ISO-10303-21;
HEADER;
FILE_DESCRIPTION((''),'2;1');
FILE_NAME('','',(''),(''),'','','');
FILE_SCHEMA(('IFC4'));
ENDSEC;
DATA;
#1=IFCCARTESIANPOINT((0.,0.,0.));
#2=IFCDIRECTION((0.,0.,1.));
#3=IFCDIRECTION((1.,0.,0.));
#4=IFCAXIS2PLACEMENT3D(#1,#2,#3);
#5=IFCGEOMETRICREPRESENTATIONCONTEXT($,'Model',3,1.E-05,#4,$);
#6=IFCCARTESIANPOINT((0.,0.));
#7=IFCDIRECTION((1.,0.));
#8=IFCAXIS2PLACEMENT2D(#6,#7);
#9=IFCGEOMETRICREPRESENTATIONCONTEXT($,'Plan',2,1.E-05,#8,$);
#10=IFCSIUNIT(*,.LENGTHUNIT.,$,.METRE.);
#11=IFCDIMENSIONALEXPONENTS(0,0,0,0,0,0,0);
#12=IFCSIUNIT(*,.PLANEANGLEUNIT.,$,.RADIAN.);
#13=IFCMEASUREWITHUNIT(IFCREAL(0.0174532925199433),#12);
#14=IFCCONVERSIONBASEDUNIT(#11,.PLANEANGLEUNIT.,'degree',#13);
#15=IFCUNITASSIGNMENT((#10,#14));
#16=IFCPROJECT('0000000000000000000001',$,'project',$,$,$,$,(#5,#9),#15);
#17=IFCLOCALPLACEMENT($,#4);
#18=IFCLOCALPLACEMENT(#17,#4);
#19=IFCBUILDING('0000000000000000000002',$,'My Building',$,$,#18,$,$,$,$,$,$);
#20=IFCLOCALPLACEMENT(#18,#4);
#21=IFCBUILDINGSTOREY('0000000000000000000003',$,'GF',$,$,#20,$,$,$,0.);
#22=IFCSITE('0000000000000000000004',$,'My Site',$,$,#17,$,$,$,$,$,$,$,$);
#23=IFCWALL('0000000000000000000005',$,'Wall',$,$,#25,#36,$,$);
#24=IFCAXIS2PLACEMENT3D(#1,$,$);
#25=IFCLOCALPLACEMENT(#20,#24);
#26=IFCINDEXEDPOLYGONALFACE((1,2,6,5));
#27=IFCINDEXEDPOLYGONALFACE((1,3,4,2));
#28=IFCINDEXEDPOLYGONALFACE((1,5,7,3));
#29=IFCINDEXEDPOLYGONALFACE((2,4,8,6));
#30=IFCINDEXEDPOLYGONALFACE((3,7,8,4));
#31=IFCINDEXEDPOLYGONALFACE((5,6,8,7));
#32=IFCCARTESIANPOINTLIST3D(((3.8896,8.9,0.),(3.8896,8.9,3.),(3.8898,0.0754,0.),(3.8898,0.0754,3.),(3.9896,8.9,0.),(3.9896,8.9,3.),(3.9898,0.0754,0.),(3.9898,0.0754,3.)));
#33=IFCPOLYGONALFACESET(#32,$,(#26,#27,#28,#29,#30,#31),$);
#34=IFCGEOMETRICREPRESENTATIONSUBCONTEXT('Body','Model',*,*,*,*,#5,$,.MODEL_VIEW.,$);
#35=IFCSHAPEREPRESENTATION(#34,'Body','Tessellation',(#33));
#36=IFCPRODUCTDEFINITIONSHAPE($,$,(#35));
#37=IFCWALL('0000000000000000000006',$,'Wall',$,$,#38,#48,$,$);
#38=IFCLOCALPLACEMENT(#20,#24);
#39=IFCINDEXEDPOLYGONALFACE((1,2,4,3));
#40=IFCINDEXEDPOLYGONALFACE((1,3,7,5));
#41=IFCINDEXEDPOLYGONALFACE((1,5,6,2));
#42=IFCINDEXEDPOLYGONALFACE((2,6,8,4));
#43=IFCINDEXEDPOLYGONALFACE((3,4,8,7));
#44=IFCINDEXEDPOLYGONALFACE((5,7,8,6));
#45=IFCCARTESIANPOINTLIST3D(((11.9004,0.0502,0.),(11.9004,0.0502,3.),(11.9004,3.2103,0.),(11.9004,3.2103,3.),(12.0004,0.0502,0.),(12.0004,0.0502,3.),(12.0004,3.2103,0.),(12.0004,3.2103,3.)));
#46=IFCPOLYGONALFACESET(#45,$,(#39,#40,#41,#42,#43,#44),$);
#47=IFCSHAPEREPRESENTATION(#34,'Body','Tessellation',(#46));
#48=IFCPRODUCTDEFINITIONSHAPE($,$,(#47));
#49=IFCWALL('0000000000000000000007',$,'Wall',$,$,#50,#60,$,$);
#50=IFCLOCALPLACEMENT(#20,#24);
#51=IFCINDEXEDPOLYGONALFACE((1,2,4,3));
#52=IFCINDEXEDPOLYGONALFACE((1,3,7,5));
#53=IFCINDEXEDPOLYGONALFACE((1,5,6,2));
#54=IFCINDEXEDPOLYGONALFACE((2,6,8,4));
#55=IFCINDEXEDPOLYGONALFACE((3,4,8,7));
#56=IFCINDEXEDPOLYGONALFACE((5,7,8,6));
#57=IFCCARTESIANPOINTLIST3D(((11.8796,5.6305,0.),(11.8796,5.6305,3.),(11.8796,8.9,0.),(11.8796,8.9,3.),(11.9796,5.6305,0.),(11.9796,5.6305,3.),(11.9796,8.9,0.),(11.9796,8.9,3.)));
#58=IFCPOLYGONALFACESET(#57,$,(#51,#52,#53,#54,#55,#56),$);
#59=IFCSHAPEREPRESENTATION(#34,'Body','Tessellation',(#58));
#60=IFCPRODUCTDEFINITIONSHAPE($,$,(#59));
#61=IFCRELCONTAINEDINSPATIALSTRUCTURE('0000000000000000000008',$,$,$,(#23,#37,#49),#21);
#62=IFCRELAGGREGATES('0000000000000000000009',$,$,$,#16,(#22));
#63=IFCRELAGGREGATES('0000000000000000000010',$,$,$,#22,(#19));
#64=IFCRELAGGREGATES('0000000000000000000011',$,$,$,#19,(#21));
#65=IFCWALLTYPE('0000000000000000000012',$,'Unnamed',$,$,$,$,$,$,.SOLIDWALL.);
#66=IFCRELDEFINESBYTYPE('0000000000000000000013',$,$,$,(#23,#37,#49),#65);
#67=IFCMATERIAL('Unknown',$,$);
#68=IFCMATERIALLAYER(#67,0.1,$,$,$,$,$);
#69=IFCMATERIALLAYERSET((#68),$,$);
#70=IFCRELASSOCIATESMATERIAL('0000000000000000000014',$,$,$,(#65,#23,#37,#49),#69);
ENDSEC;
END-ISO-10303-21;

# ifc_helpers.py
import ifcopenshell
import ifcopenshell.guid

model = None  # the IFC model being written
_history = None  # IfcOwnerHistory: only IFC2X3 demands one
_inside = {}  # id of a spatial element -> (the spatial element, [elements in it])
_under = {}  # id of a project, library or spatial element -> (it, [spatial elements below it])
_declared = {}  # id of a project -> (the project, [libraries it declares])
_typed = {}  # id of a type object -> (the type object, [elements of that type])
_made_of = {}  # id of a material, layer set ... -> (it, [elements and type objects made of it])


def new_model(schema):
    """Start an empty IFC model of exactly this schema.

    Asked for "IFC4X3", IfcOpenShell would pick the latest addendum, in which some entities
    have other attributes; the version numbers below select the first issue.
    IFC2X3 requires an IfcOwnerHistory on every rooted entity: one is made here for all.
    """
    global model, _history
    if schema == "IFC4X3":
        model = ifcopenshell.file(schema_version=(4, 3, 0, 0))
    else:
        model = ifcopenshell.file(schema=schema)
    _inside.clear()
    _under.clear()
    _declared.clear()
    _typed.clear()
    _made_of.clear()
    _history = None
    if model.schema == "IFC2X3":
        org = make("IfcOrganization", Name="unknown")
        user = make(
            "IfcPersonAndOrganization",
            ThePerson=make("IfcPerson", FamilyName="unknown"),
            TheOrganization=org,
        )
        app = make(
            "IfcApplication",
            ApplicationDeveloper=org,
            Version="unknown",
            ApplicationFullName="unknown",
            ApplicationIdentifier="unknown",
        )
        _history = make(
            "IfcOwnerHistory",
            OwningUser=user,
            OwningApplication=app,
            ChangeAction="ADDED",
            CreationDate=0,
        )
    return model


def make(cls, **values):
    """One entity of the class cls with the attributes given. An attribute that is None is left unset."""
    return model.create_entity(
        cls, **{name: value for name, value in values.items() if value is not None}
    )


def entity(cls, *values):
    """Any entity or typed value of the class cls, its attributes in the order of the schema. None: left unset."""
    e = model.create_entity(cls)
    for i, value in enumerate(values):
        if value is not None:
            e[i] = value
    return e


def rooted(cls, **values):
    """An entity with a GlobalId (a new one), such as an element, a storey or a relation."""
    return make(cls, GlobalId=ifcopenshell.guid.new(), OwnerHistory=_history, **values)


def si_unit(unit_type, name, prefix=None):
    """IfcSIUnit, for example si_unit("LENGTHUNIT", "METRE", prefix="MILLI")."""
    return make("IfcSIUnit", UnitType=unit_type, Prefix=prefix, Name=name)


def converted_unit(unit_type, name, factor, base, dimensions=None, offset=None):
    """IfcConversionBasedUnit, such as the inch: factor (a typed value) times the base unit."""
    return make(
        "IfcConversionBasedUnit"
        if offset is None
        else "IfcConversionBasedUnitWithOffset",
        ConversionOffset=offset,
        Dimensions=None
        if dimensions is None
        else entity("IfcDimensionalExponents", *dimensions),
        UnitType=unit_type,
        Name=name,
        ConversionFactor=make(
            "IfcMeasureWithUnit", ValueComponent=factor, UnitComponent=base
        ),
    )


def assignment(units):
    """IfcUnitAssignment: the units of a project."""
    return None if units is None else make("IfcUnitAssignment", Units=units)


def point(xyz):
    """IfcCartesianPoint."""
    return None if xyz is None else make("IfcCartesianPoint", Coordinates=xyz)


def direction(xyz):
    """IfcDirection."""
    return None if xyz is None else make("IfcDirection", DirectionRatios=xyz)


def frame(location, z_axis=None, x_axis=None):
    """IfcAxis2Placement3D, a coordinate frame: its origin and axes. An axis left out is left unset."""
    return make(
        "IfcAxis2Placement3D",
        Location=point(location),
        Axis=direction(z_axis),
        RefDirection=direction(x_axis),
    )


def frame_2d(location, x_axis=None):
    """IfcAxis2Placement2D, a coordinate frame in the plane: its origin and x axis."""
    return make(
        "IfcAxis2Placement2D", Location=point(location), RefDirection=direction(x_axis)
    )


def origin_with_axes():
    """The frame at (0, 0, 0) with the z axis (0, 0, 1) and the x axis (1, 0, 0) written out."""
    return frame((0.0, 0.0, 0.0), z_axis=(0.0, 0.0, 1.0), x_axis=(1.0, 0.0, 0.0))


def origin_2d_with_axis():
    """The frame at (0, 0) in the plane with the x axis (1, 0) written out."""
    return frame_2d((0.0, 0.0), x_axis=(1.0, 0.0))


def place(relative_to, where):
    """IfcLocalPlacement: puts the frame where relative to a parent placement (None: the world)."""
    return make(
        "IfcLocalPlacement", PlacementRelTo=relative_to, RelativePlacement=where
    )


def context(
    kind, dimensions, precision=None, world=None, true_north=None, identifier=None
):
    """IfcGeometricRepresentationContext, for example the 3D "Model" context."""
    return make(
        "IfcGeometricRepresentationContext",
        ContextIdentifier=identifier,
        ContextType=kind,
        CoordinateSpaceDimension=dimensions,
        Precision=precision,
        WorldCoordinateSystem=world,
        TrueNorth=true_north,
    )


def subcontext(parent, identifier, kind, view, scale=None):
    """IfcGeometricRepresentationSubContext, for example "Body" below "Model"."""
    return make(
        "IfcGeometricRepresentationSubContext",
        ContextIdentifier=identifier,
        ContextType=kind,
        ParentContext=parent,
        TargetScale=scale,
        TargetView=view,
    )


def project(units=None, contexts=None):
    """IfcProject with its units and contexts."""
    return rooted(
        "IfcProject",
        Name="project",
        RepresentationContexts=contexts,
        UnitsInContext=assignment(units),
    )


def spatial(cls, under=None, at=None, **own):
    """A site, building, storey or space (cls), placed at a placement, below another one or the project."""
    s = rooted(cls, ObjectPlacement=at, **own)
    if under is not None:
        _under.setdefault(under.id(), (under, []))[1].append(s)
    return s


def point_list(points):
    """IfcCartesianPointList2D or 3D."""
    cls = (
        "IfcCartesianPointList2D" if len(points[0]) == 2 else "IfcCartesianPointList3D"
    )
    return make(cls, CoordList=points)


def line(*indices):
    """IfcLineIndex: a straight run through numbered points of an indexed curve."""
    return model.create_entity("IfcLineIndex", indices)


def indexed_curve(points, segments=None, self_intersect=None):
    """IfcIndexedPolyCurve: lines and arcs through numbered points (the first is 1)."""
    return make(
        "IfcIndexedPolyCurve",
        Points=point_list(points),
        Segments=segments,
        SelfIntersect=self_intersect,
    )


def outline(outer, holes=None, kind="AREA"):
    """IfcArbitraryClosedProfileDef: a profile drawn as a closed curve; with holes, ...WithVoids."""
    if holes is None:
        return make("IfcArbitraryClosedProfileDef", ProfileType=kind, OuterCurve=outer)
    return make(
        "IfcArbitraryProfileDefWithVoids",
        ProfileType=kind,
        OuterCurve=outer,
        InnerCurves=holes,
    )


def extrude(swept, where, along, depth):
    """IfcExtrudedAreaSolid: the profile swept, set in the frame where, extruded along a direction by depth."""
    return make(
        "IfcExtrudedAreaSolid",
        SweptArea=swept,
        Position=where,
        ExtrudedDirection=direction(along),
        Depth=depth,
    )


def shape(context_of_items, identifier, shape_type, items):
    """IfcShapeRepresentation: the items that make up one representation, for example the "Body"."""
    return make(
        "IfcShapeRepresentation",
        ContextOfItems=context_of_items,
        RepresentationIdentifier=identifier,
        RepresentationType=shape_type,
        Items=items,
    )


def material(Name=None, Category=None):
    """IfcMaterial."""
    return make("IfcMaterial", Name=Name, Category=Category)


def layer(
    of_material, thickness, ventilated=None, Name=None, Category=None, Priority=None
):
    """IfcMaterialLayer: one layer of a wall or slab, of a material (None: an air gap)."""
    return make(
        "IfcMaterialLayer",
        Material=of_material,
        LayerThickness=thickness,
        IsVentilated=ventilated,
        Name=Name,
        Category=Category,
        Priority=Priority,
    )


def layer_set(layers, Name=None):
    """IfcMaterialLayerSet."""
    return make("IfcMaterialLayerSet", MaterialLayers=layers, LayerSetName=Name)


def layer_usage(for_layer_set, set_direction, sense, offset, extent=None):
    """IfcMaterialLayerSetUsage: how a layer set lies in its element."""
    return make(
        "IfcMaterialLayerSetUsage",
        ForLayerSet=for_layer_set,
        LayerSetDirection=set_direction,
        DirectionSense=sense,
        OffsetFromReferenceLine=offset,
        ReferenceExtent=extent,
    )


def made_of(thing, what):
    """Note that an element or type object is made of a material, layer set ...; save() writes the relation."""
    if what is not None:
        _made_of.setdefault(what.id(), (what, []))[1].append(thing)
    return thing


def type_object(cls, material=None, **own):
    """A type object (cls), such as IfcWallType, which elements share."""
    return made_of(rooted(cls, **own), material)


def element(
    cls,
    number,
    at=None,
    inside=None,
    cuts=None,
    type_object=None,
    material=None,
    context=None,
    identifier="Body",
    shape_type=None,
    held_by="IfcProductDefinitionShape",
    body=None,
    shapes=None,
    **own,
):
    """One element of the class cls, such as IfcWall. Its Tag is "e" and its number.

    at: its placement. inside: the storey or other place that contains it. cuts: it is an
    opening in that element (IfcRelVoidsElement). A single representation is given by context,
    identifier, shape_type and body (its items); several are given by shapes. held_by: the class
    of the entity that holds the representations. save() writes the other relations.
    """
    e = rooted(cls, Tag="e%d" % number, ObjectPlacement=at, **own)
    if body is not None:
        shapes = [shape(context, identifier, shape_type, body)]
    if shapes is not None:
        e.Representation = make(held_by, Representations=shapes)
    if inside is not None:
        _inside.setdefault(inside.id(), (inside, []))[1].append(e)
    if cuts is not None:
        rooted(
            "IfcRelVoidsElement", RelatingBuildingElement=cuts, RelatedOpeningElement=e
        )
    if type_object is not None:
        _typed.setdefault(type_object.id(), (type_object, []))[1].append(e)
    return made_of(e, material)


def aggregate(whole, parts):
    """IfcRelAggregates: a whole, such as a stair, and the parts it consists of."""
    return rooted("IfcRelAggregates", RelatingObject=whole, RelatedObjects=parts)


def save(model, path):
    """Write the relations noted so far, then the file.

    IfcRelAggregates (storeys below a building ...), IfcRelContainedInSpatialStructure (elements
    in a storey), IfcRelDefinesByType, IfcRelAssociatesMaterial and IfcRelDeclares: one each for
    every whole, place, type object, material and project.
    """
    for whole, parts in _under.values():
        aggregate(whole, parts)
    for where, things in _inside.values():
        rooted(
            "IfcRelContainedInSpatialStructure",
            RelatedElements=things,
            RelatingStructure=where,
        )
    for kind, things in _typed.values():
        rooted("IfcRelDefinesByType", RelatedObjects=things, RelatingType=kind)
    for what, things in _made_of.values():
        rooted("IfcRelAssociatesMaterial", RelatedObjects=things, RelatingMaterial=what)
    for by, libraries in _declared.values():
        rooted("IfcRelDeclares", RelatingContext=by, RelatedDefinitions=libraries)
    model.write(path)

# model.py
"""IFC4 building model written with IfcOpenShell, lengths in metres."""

from ifc_helpers import new_model, entity, si_unit, converted_unit, frame, origin_with_axes, origin_2d_with_axis, place, context, subcontext, project, spatial, line, indexed_curve, outline, extrude, material, layer, layer_set, layer_usage, type_object, element, save


model = new_model("IFC4")

# Units and contexts
model_context = context("Model", 3, precision=1e-05, world=origin_with_axes())
plan_context = context("Plan", 2, precision=1e-05, world=origin_2d_with_axis())
body_context_1 = subcontext(model_context, "Body", "Model", "MODEL_VIEW")
ifc_project = project(units=[si_unit("LENGTHUNIT", "METRE"), converted_unit("PLANEANGLEUNIT", "degree", entity("IfcReal", 0.0174532925199433), si_unit("PLANEANGLEUNIT", "RADIAN"), dimensions=[0, 0, 0, 0, 0, 0, 0])], contexts=[model_context, plan_context])

# Site, building, storey
site_placement = place(None, origin_with_axes())
site = spatial("IfcSite", under=ifc_project, at=site_placement, Name="My Site")
building_placement = place(site_placement, origin_with_axes())
building = spatial("IfcBuilding", under=site, at=building_placement, Name="My Building")
storey_placement = place(building_placement, origin_with_axes())
storey = spatial("IfcBuildingStorey", under=building, at=storey_placement, Name="GF", Elevation=0.0)

# Shared definitions
ifc_material = material(Name="Unknown")
ifc_layer = layer(ifc_material, 0.1)
ifc_layer_set = layer_set([ifc_layer])
wall_type = type_object("IfcWallType", Name="Unnamed", PredefinedType="SOLIDWALL", material=ifc_layer_set)

# Walls
ifc_layer_usage_1 = layer_usage(ifc_layer_set, "AXIS2", "POSITIVE", 0.0)
wall_1_placement = place(storey_placement, frame((3.9898, 0.0754, 0.0), z_axis=(0.0, 0.0, 1.0), x_axis=(-0.000021, 1.0, 0.0)))
element("IfcWall", 1, at=wall_1_placement, inside=storey, type_object=wall_type, material=ifc_layer_usage_1, Name="Wall", context=body_context_1, shape_type="SweptSolid", body=[
    extrude(outline(indexed_curve([(0.0, 0.0), (0.0, 0.1), (8.8246, 0.1), (8.8246, 0.0)], segments=[line(1, 2, 3, 4, 1)])), origin_with_axes(), (0.0, 0.0, 1.0), 3.0),
])
ifc_layer_usage_2 = layer_usage(ifc_layer_set, "AXIS2", "POSITIVE", 0.0)
wall_2_placement = place(storey_placement, frame((12.0004, 0.0502, 0.0), z_axis=(0.0, 0.0, 1.0), x_axis=(0.000013, 1.0, 0.0)))
element("IfcWall", 2, at=wall_2_placement, inside=storey, type_object=wall_type, material=ifc_layer_usage_2, Name="Wall", context=body_context_1, shape_type="SweptSolid", body=[
    extrude(outline(indexed_curve([(0.0, 0.0), (0.0, 0.1), (3.1602, 0.1), (3.1602, 0.0)], segments=[line(1, 2, 3, 4, 1)])), origin_with_axes(), (0.0, 0.0, 1.0), 3.0),
])
ifc_layer_usage_3 = layer_usage(ifc_layer_set, "AXIS2", "POSITIVE", 0.0)
wall_3_placement = place(storey_placement, frame((11.9796, 5.6305, 0.0), z_axis=(0.0, 0.0, 1.0), x_axis=(0.0, 1.0, 0.0)))
element("IfcWall", 3, at=wall_3_placement, inside=storey, type_object=wall_type, material=ifc_layer_usage_3, Name="Wall", context=body_context_1, shape_type="SweptSolid", body=[
    extrude(outline(indexed_curve([(0.0, 0.0), (0.0, 0.1), (3.2695, 0.1), (3.2695, 0.0)], segments=[line(1, 2, 3, 4, 1)])), origin_with_axes(), (0.0, 0.0, 1.0), 3.0),
])

save(model, "model.ifc")
